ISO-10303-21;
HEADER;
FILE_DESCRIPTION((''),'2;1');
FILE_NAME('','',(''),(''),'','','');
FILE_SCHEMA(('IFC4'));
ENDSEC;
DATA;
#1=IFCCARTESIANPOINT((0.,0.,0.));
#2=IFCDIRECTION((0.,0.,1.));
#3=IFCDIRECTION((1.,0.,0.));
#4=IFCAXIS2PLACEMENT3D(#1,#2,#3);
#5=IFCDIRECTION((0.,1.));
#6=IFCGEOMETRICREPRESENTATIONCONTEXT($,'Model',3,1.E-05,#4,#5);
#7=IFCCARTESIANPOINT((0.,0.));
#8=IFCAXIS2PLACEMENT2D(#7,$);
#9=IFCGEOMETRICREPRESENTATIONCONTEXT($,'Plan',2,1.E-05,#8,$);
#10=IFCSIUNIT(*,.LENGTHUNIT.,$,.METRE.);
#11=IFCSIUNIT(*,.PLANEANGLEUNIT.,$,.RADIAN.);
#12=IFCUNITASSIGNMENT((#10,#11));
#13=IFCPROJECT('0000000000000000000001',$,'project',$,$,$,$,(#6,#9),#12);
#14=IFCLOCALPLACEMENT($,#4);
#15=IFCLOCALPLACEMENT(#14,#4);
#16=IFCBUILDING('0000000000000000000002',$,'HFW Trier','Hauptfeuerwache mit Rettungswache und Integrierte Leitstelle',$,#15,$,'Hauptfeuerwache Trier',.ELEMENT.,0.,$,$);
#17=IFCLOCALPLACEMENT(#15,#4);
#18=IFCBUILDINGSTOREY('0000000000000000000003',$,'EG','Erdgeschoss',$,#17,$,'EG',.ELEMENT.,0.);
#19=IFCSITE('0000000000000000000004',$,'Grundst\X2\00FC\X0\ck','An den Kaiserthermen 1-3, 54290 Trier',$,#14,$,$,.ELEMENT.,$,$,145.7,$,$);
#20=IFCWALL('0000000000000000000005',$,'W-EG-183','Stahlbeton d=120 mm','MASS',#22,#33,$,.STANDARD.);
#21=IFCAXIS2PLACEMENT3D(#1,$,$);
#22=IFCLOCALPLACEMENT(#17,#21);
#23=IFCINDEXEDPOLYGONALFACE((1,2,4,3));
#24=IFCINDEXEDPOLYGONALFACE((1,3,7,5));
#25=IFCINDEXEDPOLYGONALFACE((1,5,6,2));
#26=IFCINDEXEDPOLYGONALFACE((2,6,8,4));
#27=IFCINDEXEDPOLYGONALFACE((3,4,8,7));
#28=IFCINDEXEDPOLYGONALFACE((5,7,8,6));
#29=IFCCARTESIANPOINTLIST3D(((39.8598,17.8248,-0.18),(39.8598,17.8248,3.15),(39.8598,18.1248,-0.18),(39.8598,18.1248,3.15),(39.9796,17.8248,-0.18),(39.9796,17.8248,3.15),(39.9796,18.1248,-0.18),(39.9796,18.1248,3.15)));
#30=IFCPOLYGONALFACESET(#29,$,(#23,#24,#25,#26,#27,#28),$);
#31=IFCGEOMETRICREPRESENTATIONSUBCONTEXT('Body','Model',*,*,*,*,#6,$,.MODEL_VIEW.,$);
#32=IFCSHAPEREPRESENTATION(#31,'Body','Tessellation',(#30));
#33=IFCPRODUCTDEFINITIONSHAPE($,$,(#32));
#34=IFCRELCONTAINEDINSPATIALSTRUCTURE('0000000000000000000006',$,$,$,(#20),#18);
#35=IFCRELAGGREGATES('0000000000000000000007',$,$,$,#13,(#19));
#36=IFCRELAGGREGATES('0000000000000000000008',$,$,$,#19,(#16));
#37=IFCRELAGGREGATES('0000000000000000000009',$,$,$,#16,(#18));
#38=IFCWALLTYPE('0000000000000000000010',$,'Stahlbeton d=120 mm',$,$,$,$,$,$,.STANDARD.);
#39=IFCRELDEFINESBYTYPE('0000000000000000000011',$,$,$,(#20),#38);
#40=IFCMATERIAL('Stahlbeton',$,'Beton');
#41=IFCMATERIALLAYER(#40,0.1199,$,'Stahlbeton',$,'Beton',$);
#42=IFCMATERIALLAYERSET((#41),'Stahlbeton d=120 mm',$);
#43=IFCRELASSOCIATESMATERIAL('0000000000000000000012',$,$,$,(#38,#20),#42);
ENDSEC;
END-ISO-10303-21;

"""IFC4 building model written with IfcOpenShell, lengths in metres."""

from ifc_helpers import new_model, si_unit, direction, frame, frame_2d, origin_with_axes, origin_2d, place, context, subcontext, project, spatial, rectangle, extrude, material, layer, layer_set, layer_usage, type_object, element, save


model = new_model("IFC4")

# Units and contexts
model_context = context("Model", 3, precision=1e-05, world=origin_with_axes(), true_north=direction((0.0, 1.0)))
plan_context = context("Plan", 2, precision=1e-05, world=origin_2d())
body_context = subcontext(model_context, "Body", "Model", "MODEL_VIEW")
ifc_project = project(units=[si_unit("LENGTHUNIT", "METRE"), si_unit("PLANEANGLEUNIT", "RADIAN")], contexts=[model_context, plan_context])

# Site, building, storey
site_placement = place(None, origin_with_axes())
site = spatial("IfcSite", under=ifc_project, at=site_placement, Name="Grundstück", Description="An den Kaiserthermen 1-3, 54290 Trier", CompositionType="ELEMENT", RefElevation=145.7)
building_placement = place(site_placement, origin_with_axes())
building = spatial("IfcBuilding", under=site, at=building_placement, Name="HFW Trier", Description="Hauptfeuerwache mit Rettungswache und Integrierte Leitstelle", LongName="Hauptfeuerwache Trier", CompositionType="ELEMENT", ElevationOfRefHeight=0.0)
storey_placement = place(building_placement, origin_with_axes())
storey = spatial("IfcBuildingStorey", under=building, at=storey_placement, Name="EG", Description="Erdgeschoss", LongName="EG", CompositionType="ELEMENT", Elevation=0.0)

# Shared definitions
ifc_material = material(Name="Stahlbeton", Category="Beton")

# Wall
ifc_layer_1 = layer(ifc_material, 0.1199, Name="Stahlbeton", Category="Beton")
ifc_layer_set_1 = layer_set([ifc_layer_1], Name="Stahlbeton d=120 mm")
ifc_layer_usage_1 = layer_usage(ifc_layer_set_1, "AXIS2", "POSITIVE", -0.0599)
wall_type_1 = type_object("IfcWallType", Name="Stahlbeton d=120 mm", PredefinedType="STANDARD", material=ifc_layer_set_1)
wall_1_placement = place(storey_placement, frame((39.9197, 18.1248, -0.18), z_axis=(0.0, 0.0, 1.0), x_axis=(0.0, -1.0, 0.0)))
element("IfcWall", 1, at=wall_1_placement, inside=storey, type_object=wall_type_1, material=ifc_layer_usage_1, Name="W-EG-183", Description="Stahlbeton d=120 mm", ObjectType="MASS", PredefinedType="STANDARD", context=body_context, shape_type="SweptSolid", body=[
    extrude(rectangle(XDim=0.3, YDim=0.1198, at=frame_2d((0.15, 0.0))), origin_with_axes(), (0.0, 0.0, 1.0), 3.33),
])

save(model, "model.ifc")
